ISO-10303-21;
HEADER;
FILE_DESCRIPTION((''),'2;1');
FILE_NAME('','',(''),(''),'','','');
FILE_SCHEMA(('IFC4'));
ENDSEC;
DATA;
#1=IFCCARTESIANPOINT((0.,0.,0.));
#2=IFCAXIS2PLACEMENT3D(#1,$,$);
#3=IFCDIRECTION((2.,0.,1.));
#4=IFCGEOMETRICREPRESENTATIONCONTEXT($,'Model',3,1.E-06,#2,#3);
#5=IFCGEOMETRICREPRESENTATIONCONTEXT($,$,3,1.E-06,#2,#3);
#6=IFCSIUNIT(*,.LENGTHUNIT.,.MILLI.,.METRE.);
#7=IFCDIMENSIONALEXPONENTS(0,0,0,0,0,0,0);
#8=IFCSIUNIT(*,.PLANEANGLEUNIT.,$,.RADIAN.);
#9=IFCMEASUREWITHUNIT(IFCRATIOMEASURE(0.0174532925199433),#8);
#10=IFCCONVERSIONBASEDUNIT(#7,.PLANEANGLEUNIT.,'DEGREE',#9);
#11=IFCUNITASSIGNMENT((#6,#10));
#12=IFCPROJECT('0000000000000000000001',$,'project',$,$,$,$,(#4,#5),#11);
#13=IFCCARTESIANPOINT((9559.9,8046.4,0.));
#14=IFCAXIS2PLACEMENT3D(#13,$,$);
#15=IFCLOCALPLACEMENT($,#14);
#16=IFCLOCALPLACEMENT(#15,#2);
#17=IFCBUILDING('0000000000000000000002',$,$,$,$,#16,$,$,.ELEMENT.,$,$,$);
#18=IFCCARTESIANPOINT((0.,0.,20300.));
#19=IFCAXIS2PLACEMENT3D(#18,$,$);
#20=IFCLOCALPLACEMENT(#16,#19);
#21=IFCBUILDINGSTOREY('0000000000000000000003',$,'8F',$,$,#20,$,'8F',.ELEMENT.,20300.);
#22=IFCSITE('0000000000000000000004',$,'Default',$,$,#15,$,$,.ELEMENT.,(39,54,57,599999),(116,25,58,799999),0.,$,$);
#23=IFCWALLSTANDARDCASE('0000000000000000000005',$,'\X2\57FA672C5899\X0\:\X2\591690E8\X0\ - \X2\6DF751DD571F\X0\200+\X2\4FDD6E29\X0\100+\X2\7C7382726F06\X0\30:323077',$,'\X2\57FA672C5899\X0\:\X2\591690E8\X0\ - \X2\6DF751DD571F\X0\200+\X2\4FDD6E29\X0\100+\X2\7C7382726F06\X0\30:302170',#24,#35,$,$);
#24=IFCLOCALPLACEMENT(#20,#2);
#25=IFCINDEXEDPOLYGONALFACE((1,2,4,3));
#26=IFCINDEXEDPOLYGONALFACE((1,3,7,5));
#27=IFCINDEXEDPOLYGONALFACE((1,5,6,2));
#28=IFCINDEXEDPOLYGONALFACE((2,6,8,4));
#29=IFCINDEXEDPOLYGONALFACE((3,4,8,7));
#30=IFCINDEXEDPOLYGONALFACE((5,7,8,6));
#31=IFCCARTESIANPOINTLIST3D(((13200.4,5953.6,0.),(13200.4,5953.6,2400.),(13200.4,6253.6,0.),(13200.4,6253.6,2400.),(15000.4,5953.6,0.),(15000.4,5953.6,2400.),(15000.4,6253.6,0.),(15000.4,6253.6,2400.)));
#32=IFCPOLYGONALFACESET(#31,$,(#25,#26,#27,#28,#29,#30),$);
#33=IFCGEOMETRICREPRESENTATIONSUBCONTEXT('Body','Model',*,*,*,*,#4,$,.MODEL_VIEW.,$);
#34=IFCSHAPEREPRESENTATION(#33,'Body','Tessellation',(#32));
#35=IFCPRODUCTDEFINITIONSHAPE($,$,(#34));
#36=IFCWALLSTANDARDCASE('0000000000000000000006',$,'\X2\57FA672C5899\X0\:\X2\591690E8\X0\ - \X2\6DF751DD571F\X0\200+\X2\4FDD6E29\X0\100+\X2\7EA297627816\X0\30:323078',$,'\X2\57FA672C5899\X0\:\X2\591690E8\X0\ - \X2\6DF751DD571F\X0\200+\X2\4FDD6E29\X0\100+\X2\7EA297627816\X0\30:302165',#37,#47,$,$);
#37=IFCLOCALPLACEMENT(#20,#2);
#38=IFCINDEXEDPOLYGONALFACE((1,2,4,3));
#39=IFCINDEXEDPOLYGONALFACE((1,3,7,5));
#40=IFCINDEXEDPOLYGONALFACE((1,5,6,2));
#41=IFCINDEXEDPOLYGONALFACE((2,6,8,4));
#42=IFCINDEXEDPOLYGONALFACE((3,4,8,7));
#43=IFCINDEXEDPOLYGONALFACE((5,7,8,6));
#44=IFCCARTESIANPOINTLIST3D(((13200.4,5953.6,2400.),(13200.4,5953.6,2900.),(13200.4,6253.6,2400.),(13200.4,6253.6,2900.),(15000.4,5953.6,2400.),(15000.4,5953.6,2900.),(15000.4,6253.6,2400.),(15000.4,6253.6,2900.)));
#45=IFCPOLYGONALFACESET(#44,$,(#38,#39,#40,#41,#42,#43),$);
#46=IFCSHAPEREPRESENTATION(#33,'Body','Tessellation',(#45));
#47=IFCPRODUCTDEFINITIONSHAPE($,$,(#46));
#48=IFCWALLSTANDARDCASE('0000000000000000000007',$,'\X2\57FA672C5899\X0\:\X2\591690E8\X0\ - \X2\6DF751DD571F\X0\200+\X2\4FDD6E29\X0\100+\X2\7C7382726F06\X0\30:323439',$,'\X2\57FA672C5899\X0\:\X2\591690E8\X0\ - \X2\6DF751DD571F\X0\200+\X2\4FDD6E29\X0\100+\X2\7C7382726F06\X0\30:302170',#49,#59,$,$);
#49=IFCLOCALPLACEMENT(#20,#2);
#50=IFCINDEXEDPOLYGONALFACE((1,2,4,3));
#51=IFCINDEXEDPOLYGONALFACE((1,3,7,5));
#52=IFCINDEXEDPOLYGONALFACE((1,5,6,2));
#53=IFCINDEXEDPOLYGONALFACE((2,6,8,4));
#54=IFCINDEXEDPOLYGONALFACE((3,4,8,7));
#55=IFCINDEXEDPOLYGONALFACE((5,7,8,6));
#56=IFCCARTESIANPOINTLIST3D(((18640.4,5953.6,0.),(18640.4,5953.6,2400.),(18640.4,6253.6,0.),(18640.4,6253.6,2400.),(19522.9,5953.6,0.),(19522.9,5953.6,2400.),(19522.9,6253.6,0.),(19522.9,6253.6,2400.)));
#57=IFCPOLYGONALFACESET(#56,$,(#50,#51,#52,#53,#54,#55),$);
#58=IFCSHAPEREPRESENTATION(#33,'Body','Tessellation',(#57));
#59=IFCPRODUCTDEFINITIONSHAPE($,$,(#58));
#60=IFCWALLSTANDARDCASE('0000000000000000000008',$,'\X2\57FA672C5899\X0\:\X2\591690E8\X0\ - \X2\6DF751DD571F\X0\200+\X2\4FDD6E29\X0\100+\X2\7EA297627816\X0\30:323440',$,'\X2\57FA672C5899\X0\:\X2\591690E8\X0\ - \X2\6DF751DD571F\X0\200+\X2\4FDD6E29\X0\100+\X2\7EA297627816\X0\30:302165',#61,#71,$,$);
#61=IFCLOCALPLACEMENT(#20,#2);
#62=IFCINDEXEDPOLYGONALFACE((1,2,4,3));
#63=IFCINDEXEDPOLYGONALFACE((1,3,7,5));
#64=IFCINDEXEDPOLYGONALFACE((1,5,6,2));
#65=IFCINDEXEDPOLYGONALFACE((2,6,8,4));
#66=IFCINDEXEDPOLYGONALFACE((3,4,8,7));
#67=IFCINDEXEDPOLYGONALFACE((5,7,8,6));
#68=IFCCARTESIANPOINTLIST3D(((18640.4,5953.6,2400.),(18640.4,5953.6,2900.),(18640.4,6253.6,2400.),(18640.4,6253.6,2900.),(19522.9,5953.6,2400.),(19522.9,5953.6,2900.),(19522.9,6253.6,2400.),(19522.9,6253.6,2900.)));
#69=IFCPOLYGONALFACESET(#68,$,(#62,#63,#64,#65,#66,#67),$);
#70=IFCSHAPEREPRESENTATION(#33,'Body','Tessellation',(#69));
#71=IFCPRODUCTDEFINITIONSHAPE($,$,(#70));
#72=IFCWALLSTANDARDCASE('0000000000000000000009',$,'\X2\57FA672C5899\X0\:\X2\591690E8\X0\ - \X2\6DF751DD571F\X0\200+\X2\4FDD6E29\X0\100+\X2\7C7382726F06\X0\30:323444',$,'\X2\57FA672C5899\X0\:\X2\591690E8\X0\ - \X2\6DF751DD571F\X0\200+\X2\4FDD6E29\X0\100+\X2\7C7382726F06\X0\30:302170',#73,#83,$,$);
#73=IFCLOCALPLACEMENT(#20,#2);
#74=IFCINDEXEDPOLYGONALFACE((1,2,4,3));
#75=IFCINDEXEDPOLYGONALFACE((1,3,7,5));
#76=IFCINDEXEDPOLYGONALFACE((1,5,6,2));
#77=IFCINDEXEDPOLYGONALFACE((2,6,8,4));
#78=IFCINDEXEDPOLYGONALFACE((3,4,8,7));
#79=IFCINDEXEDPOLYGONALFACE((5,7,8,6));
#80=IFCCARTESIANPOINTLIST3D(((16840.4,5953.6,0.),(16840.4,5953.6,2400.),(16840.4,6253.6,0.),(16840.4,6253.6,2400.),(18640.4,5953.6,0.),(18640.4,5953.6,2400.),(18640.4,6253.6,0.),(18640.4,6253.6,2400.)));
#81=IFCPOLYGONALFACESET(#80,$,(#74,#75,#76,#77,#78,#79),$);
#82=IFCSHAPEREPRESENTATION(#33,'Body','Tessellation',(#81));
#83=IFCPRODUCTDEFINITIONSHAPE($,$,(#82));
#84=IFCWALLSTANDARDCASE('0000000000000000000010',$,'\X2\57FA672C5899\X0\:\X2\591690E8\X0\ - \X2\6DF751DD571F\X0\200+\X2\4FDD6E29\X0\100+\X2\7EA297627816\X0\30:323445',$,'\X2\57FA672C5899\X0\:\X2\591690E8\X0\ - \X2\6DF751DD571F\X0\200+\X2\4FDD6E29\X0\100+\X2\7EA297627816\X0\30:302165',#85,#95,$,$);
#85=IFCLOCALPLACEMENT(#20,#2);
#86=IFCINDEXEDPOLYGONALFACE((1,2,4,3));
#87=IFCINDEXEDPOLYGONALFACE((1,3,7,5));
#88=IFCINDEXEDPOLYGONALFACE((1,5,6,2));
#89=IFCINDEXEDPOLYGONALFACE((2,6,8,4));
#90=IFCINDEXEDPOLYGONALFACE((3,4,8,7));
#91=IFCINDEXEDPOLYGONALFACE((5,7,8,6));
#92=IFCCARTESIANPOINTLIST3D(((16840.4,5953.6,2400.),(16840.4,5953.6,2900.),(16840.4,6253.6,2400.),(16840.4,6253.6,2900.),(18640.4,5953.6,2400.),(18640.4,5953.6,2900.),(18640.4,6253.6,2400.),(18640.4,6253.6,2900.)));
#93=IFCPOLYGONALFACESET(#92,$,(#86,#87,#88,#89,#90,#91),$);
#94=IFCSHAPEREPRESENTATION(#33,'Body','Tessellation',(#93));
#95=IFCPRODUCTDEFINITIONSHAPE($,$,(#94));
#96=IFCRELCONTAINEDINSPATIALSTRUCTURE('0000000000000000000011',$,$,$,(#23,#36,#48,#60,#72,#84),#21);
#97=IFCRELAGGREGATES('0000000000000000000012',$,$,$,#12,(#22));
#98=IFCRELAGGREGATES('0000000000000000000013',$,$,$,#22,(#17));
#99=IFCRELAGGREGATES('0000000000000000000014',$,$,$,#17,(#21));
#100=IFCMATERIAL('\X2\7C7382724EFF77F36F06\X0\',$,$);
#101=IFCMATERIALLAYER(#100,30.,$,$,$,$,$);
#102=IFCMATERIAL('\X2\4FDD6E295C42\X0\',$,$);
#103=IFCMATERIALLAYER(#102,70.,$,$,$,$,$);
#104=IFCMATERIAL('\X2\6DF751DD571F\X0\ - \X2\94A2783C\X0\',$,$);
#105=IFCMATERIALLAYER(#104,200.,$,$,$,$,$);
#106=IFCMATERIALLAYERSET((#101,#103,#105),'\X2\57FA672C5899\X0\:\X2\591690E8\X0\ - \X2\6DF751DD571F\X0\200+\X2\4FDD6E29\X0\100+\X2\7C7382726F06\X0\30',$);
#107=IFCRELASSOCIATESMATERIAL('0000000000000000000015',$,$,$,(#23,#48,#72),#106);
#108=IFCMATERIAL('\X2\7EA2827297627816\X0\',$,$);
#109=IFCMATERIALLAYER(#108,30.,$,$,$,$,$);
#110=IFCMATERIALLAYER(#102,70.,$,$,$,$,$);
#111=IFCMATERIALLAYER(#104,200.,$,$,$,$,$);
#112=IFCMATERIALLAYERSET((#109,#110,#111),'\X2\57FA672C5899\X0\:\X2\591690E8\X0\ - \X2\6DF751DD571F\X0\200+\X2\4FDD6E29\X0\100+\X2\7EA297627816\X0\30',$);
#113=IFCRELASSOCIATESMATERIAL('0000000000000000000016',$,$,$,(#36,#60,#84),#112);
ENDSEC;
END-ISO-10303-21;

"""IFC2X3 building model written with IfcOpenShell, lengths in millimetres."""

from ifc_helpers import new_model, entity, si_unit, converted_unit, direction, frame, frame_2d, origin, place, context, subcontext, project, spatial, rectangle, extrude, material, layer, layer_set, layer_usage, element, save


model = new_model("IFC2X3")

# Units and contexts
model_context = context("Model", 3, precision=1e-06, world=origin(), true_north=direction((2.0, 0.0, 1.0)))
context_of_model = context(None, 3, precision=1e-06, world=origin(), true_north=direction((2.0, 0.0, 1.0)))
body_context = subcontext(model_context, "Body", "Model", "MODEL_VIEW")
ifc_project = project(units=[si_unit("LENGTHUNIT", "METRE", prefix="MILLI"), converted_unit("PLANEANGLEUNIT", "DEGREE", entity("IfcRatioMeasure", 0.0174532925199433), si_unit("PLANEANGLEUNIT", "RADIAN"), dimensions=[0, 0, 0, 0, 0, 0, 0])], contexts=[model_context, context_of_model])

# Site, building, storey
site_placement = place(None, frame((9559.9, 8046.4, 0.0)))
site = spatial("IfcSite", under=ifc_project, at=site_placement, Name="Default", CompositionType="ELEMENT", RefLatitude=(39, 54, 57, 599999), RefLongitude=(116, 25, 58, 799999), RefElevation=0.0)
building_placement = place(site_placement, origin())
building = spatial("IfcBuilding", under=site, at=building_placement, CompositionType="ELEMENT")
storey_placement = place(building_placement, frame((0.0, 0.0, 20300.0)))
storey = spatial("IfcBuildingStorey", under=building, at=storey_placement, Name="8F", LongName="8F", CompositionType="ELEMENT", Elevation=20300.0)

# Shared definitions
ifc_material_1 = material(Name="红色面砖")
ifc_layer_1 = layer(ifc_material_1, 30.0)
ifc_material_2 = material(Name="保温层")
ifc_layer_2 = layer(ifc_material_2, 70.0)
ifc_material_3 = material(Name="混凝土 - 钢砼")
ifc_layer_3 = layer(ifc_material_3, 200.0)
ifc_layer_set_1 = layer_set([ifc_layer_1, ifc_layer_2, ifc_layer_3], Name="基本墙:外部 - 混凝土200+保温100+红面砖30")

# Walls
ifc_material_4 = material(Name="米色仿石漆")
ifc_layer_4 = layer(ifc_material_4, 30.0)
ifc_layer_5 = layer(ifc_material_2, 70.0)
ifc_layer_6 = layer(ifc_material_3, 200.0)
ifc_layer_set_2 = layer_set([ifc_layer_4, ifc_layer_5, ifc_layer_6], Name="基本墙:外部 - 混凝土200+保温100+米色漆30")
ifc_layer_usage_1 = layer_usage(ifc_layer_set_2, "AXIS2", "POSITIVE", -150.0)
wall_1_placement = place(storey_placement, frame((15000.4, 6103.6, 0.0), z_axis=(0.0, 0.0, 1.0), x_axis=(-1.0, 0.0, 0.0)))
element("IfcWallStandardCase", 1, at=wall_1_placement, inside=storey, material=ifc_layer_usage_1, Name="基本墙:外部 - 混凝土200+保温100+米色漆30:323077", ObjectType="基本墙:外部 - 混凝土200+保温100+米色漆30:302170", context=body_context, shape_type="SweptSolid", body=[
    extrude(rectangle(XDim=1800.0, YDim=300.0, at=frame_2d((900.0, 0.0), x_axis=(-1.0, 0.0))), origin(), (0.0, 0.0, 1.0), 2400.0),
])
ifc_layer_usage_2 = layer_usage(ifc_layer_set_1, "AXIS2", "POSITIVE", -150.0)
wall_2_placement = place(storey_placement, frame((15000.4, 6103.6, 2400.0), z_axis=(0.0, 0.0, 1.0), x_axis=(-1.0, 0.0, 0.0)))
element("IfcWallStandardCase", 2, at=wall_2_placement, inside=storey, material=ifc_layer_usage_2, Name="基本墙:外部 - 混凝土200+保温100+红面砖30:323078", ObjectType="基本墙:外部 - 混凝土200+保温100+红面砖30:302165", context=body_context, shape_type="SweptSolid", body=[
    extrude(rectangle(XDim=1800.0, YDim=300.0, at=frame_2d((900.0, 0.0), x_axis=(-1.0, 0.0))), origin(), (0.0, 0.0, 1.0), 500.0),
])

# Walls
ifc_layer_usage_3 = layer_usage(ifc_layer_set_2, "AXIS2", "NEGATIVE", 150.0)
wall_3_placement = place(storey_placement, frame((18640.4, 6103.6, 0.0)))
element("IfcWallStandardCase", 3, at=wall_3_placement, inside=storey, material=ifc_layer_usage_3, Name="基本墙:外部 - 混凝土200+保温100+米色漆30:323439", ObjectType="基本墙:外部 - 混凝土200+保温100+米色漆30:302170", context=body_context, shape_type="SweptSolid", body=[
    extrude(rectangle(XDim=882.5, YDim=300.0, at=frame_2d((441.3, 0.0), x_axis=(-1.0, 0.0))), origin(), (0.0, 0.0, 1.0), 2400.0),
])
ifc_layer_usage_4 = layer_usage(ifc_layer_set_1, "AXIS2", "NEGATIVE", 150.0)
wall_4_placement = place(storey_placement, frame((18640.4, 6103.6, 2400.0)))
element("IfcWallStandardCase", 4, at=wall_4_placement, inside=storey, material=ifc_layer_usage_4, Name="基本墙:外部 - 混凝土200+保温100+红面砖30:323440", ObjectType="基本墙:外部 - 混凝土200+保温100+红面砖30:302165", context=body_context, shape_type="SweptSolid", body=[
    extrude(rectangle(XDim=882.5, YDim=300.0, at=frame_2d((441.3, 0.0), x_axis=(-1.0, 0.0))), origin(), (0.0, 0.0, 1.0), 500.0),
])
ifc_layer_usage_5 = layer_usage(ifc_layer_set_2, "AXIS2", "NEGATIVE", 150.0)
wall_5_placement = place(storey_placement, frame((16840.4, 6103.6, 0.0)))
element("IfcWallStandardCase", 5, at=wall_5_placement, inside=storey, material=ifc_layer_usage_5, Name="基本墙:外部 - 混凝土200+保温100+米色漆30:323444", ObjectType="基本墙:外部 - 混凝土200+保温100+米色漆30:302170", context=body_context, shape_type="SweptSolid", body=[
    extrude(rectangle(XDim=1800.0, YDim=300.0, at=frame_2d((900.0, 0.0), x_axis=(-1.0, 0.0))), origin(), (0.0, 0.0, 1.0), 2400.0),
])
ifc_layer_usage_6 = layer_usage(ifc_layer_set_1, "AXIS2", "NEGATIVE", 150.0)
wall_6_placement = place(storey_placement, frame((16840.4, 6103.6, 2400.0)))
element("IfcWallStandardCase", 6, at=wall_6_placement, inside=storey, material=ifc_layer_usage_6, Name="基本墙:外部 - 混凝土200+保温100+红面砖30:323445", ObjectType="基本墙:外部 - 混凝土200+保温100+红面砖30:302165", context=body_context, shape_type="SweptSolid", body=[
    extrude(rectangle(XDim=1800.0, YDim=300.0, at=frame_2d((900.0, 0.0), x_axis=(-1.0, 0.0))), origin(), (0.0, 0.0, 1.0), 500.0),
])

save(model, "model.ifc")
